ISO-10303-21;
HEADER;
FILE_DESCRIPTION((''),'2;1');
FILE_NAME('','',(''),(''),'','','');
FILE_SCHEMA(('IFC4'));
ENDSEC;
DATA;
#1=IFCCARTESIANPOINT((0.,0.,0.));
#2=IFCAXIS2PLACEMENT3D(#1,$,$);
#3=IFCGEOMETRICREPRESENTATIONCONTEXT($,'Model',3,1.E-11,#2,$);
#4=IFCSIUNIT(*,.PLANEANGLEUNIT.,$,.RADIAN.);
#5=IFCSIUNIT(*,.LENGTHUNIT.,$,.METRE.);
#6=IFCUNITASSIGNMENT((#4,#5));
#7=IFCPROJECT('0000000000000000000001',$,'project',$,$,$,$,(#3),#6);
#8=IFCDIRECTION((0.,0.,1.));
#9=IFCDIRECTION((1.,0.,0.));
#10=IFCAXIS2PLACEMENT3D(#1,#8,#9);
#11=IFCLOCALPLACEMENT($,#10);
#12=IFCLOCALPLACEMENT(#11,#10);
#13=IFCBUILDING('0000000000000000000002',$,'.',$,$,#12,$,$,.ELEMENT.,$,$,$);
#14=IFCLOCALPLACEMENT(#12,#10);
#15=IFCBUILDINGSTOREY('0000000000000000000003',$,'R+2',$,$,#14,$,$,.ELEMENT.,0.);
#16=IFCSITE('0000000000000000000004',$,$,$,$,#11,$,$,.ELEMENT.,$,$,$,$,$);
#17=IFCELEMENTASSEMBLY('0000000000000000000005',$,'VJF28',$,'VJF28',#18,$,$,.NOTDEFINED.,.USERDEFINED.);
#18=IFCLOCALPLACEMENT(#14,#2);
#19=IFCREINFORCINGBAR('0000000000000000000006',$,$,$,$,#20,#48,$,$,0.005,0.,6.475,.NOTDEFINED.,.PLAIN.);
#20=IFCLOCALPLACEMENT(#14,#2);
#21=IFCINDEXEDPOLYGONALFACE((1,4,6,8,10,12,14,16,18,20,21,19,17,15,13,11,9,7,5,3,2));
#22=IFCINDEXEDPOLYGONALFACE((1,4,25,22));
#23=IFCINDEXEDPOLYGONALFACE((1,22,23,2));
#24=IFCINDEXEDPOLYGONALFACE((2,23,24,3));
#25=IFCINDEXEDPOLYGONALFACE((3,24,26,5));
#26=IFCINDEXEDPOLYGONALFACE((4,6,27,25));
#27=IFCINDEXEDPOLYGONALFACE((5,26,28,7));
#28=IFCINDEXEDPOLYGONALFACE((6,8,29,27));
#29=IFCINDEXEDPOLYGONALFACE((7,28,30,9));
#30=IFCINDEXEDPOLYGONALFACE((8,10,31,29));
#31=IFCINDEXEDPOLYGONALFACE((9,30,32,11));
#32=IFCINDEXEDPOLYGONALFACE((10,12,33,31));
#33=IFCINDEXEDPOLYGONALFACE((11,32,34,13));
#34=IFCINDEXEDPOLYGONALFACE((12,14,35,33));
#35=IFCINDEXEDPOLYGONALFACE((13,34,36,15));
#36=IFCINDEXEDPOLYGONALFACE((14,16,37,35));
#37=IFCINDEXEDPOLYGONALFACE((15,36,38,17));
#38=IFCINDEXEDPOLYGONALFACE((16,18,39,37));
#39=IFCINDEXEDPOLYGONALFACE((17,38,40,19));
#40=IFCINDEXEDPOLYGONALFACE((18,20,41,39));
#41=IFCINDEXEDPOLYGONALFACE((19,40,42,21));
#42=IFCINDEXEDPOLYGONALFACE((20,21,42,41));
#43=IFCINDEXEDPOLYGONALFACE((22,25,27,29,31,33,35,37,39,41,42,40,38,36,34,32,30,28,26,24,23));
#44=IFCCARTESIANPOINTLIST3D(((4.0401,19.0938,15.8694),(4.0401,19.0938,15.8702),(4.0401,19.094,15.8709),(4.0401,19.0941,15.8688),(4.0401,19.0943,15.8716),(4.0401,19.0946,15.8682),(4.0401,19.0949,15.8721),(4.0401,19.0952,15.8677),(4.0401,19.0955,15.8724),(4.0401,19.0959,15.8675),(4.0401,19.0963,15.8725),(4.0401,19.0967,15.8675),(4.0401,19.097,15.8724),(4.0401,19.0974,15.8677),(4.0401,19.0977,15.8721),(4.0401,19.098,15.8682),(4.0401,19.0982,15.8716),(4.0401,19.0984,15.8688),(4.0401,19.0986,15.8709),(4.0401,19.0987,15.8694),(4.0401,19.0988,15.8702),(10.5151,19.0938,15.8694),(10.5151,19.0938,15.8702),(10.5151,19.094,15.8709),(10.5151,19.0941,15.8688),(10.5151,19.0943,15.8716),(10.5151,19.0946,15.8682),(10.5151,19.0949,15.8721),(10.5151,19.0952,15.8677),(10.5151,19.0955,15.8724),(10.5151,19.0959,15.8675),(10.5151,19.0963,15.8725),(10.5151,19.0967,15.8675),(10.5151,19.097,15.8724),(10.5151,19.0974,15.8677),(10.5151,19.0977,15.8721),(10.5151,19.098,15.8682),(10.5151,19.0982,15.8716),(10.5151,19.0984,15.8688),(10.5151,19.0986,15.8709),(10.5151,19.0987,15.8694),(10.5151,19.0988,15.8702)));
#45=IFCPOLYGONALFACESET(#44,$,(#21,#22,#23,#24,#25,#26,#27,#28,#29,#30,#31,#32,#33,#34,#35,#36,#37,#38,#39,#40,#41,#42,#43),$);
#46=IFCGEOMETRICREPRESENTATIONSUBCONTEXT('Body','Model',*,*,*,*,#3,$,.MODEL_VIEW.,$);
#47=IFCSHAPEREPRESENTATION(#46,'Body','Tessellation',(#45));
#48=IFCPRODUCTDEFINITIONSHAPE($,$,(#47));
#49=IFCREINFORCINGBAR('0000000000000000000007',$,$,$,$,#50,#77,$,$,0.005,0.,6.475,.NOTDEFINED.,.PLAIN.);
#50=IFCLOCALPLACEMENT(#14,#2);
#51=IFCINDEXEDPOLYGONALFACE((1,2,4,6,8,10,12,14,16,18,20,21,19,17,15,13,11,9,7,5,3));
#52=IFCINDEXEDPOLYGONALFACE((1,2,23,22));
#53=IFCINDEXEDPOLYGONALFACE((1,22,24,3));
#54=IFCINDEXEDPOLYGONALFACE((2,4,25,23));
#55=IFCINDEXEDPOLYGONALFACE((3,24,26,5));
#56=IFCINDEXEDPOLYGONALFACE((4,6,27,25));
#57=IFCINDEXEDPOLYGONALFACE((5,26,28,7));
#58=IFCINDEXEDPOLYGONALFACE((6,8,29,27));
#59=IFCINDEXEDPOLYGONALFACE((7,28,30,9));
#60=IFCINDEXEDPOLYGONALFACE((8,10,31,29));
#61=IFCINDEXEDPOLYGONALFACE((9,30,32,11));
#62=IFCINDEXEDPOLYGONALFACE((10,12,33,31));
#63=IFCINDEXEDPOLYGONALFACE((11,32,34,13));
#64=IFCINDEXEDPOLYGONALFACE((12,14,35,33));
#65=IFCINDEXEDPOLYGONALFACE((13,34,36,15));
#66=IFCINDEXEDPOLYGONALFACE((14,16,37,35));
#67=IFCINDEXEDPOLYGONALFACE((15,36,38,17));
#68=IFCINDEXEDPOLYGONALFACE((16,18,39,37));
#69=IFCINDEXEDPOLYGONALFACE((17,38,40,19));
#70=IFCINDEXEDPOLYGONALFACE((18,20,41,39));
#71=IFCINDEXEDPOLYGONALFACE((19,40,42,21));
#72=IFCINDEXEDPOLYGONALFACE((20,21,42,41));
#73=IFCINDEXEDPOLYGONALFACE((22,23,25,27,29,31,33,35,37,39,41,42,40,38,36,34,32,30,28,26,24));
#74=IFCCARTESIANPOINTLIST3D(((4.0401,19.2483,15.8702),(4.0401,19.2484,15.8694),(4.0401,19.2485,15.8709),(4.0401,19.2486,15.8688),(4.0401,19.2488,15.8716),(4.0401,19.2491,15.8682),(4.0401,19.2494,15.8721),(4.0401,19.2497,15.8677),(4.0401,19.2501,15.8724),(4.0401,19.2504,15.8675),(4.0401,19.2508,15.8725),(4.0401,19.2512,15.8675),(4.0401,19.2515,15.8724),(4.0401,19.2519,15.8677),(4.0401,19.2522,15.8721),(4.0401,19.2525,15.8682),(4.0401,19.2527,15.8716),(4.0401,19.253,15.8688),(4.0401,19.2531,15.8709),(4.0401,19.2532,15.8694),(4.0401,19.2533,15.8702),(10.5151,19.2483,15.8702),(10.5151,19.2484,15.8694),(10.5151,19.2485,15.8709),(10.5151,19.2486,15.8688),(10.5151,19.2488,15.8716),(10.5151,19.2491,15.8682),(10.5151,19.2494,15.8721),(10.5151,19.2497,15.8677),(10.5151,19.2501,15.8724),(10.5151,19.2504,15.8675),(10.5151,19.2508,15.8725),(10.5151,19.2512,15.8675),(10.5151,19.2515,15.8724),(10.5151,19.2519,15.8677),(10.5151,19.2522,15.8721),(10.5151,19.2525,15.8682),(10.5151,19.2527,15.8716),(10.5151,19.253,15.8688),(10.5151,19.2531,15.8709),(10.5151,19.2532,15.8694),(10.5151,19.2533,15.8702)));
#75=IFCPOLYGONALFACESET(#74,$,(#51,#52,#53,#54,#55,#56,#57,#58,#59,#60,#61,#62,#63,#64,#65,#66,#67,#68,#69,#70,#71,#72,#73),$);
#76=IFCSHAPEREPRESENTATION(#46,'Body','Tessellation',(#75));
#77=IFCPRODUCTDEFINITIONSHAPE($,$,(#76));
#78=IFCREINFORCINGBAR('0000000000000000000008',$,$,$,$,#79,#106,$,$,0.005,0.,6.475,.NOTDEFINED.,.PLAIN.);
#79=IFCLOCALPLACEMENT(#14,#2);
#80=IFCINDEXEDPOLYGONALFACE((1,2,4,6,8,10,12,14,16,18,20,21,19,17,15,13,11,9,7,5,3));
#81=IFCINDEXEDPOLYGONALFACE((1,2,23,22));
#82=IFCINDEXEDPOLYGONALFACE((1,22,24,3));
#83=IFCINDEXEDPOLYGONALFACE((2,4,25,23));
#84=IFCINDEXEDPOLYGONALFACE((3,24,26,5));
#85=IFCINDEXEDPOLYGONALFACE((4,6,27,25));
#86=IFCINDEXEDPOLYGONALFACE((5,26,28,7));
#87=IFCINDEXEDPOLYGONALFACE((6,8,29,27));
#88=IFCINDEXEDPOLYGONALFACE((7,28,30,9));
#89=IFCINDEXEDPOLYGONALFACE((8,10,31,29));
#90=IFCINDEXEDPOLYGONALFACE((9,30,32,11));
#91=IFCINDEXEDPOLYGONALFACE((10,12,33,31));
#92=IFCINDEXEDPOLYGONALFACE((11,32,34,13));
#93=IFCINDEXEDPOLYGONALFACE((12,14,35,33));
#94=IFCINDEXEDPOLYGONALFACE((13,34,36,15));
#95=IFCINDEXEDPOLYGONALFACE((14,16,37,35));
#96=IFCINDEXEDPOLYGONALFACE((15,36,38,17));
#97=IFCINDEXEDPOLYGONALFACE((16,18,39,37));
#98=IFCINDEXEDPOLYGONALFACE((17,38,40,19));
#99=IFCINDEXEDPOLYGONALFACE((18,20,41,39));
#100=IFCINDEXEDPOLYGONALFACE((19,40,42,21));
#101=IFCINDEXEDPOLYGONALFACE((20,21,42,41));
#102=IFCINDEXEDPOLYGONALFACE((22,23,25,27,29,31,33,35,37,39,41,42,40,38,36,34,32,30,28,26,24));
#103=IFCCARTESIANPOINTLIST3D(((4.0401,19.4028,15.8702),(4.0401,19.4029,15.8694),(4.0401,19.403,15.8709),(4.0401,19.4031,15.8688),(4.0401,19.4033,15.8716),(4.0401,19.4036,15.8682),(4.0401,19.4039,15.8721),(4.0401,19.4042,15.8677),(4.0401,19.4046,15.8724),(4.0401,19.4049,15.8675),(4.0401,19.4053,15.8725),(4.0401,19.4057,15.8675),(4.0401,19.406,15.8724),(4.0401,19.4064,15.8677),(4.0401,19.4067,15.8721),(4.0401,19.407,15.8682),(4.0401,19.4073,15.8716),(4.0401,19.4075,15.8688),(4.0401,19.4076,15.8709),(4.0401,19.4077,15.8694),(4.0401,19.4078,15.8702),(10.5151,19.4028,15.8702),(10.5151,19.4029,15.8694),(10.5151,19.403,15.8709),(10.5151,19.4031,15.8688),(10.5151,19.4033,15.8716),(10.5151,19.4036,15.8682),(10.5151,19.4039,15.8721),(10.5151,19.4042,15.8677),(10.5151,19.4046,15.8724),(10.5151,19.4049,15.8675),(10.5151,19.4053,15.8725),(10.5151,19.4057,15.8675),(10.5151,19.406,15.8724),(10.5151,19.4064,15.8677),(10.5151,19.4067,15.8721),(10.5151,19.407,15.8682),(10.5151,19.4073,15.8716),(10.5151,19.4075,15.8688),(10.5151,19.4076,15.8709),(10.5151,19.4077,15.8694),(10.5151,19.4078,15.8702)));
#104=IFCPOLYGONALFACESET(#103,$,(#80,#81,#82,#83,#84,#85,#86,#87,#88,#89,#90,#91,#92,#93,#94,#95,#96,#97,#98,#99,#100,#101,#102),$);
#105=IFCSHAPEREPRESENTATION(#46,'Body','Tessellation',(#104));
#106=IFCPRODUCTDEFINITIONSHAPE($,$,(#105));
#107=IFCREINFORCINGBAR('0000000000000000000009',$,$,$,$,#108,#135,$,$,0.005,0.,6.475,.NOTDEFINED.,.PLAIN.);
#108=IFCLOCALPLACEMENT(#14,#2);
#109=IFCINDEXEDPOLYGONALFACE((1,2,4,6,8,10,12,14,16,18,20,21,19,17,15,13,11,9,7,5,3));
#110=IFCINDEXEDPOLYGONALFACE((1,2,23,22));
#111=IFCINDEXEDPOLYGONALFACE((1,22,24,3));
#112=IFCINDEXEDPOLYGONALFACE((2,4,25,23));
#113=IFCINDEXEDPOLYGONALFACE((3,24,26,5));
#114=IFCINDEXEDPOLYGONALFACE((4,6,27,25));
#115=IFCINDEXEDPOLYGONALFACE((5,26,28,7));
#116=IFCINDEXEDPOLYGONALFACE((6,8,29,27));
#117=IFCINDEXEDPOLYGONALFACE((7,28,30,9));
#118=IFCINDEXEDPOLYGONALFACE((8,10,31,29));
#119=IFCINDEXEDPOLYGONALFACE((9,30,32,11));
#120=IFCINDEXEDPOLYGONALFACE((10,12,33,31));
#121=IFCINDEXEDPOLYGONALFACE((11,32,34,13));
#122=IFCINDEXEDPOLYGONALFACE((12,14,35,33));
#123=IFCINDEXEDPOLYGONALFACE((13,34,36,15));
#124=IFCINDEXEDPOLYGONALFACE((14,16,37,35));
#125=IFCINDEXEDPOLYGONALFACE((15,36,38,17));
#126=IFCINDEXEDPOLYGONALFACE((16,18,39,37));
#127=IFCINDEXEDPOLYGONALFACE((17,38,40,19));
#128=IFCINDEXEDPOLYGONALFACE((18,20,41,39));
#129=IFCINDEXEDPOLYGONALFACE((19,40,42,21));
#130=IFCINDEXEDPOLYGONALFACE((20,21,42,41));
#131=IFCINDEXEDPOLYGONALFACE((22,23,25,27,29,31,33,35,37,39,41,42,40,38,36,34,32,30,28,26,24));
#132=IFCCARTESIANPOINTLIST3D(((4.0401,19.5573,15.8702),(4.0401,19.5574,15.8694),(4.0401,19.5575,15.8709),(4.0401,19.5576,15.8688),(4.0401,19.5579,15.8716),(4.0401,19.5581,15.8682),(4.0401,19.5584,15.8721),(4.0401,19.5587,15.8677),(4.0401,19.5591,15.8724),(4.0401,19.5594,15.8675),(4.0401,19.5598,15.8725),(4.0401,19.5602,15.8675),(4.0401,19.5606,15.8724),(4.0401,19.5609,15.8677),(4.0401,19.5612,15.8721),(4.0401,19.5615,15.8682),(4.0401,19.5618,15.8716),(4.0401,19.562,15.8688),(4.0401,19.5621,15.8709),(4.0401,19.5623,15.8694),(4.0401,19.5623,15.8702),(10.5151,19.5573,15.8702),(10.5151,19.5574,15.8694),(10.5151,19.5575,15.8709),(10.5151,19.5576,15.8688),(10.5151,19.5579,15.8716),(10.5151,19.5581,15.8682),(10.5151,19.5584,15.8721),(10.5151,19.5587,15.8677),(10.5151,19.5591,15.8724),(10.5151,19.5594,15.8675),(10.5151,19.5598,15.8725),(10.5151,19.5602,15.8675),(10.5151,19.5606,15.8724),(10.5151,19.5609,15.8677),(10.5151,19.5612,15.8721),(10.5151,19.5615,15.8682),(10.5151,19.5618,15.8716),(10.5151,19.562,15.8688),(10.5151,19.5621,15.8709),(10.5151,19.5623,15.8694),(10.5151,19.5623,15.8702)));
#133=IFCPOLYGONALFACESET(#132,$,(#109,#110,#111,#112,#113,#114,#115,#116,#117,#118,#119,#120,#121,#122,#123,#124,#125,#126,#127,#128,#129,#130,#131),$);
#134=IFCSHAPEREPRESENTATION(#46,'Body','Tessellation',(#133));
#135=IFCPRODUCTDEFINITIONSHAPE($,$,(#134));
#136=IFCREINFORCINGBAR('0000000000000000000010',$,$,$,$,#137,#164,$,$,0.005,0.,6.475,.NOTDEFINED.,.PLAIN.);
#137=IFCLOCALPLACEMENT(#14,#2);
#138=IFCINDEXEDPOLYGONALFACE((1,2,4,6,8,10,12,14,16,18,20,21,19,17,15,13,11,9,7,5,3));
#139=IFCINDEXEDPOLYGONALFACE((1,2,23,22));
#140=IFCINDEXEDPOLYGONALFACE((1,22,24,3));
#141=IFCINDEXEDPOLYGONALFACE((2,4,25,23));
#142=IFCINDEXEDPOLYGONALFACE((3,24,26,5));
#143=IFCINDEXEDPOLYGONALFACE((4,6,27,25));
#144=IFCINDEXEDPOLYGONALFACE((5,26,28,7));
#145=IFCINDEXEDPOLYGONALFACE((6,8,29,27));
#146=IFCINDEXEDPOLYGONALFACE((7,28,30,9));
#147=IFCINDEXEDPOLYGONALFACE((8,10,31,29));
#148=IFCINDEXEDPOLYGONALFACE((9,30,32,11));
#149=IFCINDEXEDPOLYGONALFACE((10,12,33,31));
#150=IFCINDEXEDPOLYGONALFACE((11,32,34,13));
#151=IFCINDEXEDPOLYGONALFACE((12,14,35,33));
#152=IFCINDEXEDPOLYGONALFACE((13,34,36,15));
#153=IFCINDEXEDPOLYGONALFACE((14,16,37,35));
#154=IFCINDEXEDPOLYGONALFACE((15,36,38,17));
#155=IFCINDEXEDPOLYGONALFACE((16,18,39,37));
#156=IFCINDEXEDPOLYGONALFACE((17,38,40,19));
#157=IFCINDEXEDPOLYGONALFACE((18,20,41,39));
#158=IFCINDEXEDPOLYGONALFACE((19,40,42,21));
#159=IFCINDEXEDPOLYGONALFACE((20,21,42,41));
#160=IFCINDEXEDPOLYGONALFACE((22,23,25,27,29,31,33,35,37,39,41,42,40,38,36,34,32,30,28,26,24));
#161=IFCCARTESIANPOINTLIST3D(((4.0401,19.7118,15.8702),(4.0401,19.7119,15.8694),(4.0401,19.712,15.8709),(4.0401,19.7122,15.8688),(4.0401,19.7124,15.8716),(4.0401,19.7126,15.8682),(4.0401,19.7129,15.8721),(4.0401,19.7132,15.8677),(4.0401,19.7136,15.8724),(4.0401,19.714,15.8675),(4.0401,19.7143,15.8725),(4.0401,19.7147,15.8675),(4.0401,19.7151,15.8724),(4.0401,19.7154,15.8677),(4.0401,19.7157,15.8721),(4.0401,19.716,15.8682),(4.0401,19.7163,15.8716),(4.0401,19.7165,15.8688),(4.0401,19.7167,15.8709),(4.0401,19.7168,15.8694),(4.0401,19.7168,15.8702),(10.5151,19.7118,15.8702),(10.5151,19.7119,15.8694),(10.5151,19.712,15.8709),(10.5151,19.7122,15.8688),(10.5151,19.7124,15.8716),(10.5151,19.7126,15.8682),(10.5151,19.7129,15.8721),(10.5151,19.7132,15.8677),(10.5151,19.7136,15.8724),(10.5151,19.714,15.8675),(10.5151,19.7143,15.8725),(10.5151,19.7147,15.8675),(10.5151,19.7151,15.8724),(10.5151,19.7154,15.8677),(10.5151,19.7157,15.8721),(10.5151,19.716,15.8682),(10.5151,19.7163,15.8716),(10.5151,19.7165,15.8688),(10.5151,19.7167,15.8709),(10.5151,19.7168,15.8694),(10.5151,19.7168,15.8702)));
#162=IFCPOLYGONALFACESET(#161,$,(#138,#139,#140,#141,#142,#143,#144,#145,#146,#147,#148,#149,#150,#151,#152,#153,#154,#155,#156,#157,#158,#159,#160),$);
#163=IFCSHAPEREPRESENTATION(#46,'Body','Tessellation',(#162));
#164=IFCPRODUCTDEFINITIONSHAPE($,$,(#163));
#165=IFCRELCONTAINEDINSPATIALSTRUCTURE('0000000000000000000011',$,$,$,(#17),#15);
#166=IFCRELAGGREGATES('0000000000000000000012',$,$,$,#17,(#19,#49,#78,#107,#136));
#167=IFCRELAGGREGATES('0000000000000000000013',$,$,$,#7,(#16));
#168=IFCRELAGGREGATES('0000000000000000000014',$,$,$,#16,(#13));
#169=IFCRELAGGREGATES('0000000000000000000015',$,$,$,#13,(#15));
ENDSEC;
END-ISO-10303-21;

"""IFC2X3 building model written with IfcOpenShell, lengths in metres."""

from ifc_helpers import new_model, entity, si_unit, origin, origin_with_axes, place, context, subcontext, project, spatial, shape, element, aggregate, save


model = new_model("IFC2X3")

# Units and contexts
model_context = context("Model", 3, precision=1e-11, world=origin())
body_context = subcontext(model_context, "Body", "Model", "MODEL_VIEW")
ifc_project = project(units=[si_unit("PLANEANGLEUNIT", "RADIAN"), si_unit("LENGTHUNIT", "METRE")], contexts=[model_context])

# Site, building, storey
site_placement = place(None, origin_with_axes())
site = spatial("IfcSite", under=ifc_project, at=site_placement, CompositionType="ELEMENT")
building_placement = place(site_placement, origin_with_axes())
building = spatial("IfcBuilding", under=site, at=building_placement, Name=".", CompositionType="ELEMENT")
storey_placement = place(building_placement, origin_with_axes())
storey = spatial("IfcBuildingStorey", under=building, at=storey_placement, Name="R+2", CompositionType="ELEMENT", Elevation=0.0)

# Element assembly, reinforcing bars
assembly_1_placement = place(storey_placement, origin_with_axes())
assembly_1 = element("IfcElementAssembly", 1, at=assembly_1_placement, inside=storey, Name="VJF28", ObjectType="VJF28", AssemblyPlace="NOTDEFINED", PredefinedType="USERDEFINED")
reinforcing_bar_1_placement = place(assembly_1_placement, origin_with_axes())
reinforcing_bar_1 = element("IfcReinforcingBar", 2, at=reinforcing_bar_1_placement, BarLength=6.475, BarRole="NOTDEFINED", BarSurface="PLAIN", CrossSectionArea=0.0, NominalDiameter=0.005, shapes=[
    shape(body_context, "Body", "AdvancedSweptSolid", [entity("IfcSweptDiskSolid", entity("IfcPolyline", [entity("IfcCartesianPoint", [4.0401, 19.0963, 15.87]), entity("IfcCartesianPoint", [10.5151, 19.0963, 15.87])]), 0.0025, None, 0.0, 6.475)]),
    shape(body_context, "Body", "AdvancedSweptSolid", [entity("IfcSweptDiskSolid", entity("IfcPolyline", [entity("IfcCartesianPoint", [4.0401, 19.0963, 15.87]), entity("IfcCartesianPoint", [10.5151, 19.0963, 15.87])]), 0.0025, None, 0.0, 6.475)]),
])
reinforcing_bar_2_placement = place(assembly_1_placement, origin_with_axes())
reinforcing_bar_2 = element("IfcReinforcingBar", 3, at=reinforcing_bar_2_placement, BarLength=6.475, BarRole="NOTDEFINED", BarSurface="PLAIN", CrossSectionArea=0.0, NominalDiameter=0.005, shapes=[
    shape(body_context, "Body", "AdvancedSweptSolid", [entity("IfcSweptDiskSolid", entity("IfcPolyline", [entity("IfcCartesianPoint", [4.0401, 19.2508, 15.87]), entity("IfcCartesianPoint", [10.5151, 19.2508, 15.87])]), 0.0025, None, 0.0, 6.475)]),
    shape(body_context, "Body", "AdvancedSweptSolid", [entity("IfcSweptDiskSolid", entity("IfcPolyline", [entity("IfcCartesianPoint", [4.0401, 19.2508, 15.87]), entity("IfcCartesianPoint", [10.5151, 19.2508, 15.87])]), 0.0025, None, 0.0, 6.475)]),
])
reinforcing_bar_3_placement = place(assembly_1_placement, origin_with_axes())
reinforcing_bar_3 = element("IfcReinforcingBar", 4, at=reinforcing_bar_3_placement, BarLength=6.475, BarRole="NOTDEFINED", BarSurface="PLAIN", CrossSectionArea=0.0, NominalDiameter=0.005, shapes=[
    shape(body_context, "Body", "AdvancedSweptSolid", [entity("IfcSweptDiskSolid", entity("IfcPolyline", [entity("IfcCartesianPoint", [4.0401, 19.4053, 15.87]), entity("IfcCartesianPoint", [10.5151, 19.4053, 15.87])]), 0.0025, None, 0.0, 6.475)]),
    shape(body_context, "Body", "AdvancedSweptSolid", [entity("IfcSweptDiskSolid", entity("IfcPolyline", [entity("IfcCartesianPoint", [4.0401, 19.4053, 15.87]), entity("IfcCartesianPoint", [10.5151, 19.4053, 15.87])]), 0.0025, None, 0.0, 6.475)]),
])
reinforcing_bar_4_placement = place(assembly_1_placement, origin_with_axes())
reinforcing_bar_4 = element("IfcReinforcingBar", 5, at=reinforcing_bar_4_placement, BarLength=6.475, BarRole="NOTDEFINED", BarSurface="PLAIN", CrossSectionArea=0.0, NominalDiameter=0.005, shapes=[
    shape(body_context, "Body", "AdvancedSweptSolid", [entity("IfcSweptDiskSolid", entity("IfcPolyline", [entity("IfcCartesianPoint", [4.0401, 19.5598, 15.87]), entity("IfcCartesianPoint", [10.5151, 19.5598, 15.87])]), 0.0025, None, 0.0, 6.475)]),
    shape(body_context, "Body", "AdvancedSweptSolid", [entity("IfcSweptDiskSolid", entity("IfcPolyline", [entity("IfcCartesianPoint", [4.0401, 19.5598, 15.87]), entity("IfcCartesianPoint", [10.5151, 19.5598, 15.87])]), 0.0025, None, 0.0, 6.475)]),
])
reinforcing_bar_5_placement = place(assembly_1_placement, origin_with_axes())
reinforcing_bar_5 = element("IfcReinforcingBar", 6, at=reinforcing_bar_5_placement, BarLength=6.475, BarRole="NOTDEFINED", BarSurface="PLAIN", CrossSectionArea=0.0, NominalDiameter=0.005, shapes=[
    shape(body_context, "Body", "AdvancedSweptSolid", [entity("IfcSweptDiskSolid", entity("IfcPolyline", [entity("IfcCartesianPoint", [4.0401, 19.7143, 15.87]), entity("IfcCartesianPoint", [10.5151, 19.7143, 15.87])]), 0.0025, None, 0.0, 6.475)]),
    shape(body_context, "Body", "AdvancedSweptSolid", [entity("IfcSweptDiskSolid", entity("IfcPolyline", [entity("IfcCartesianPoint", [4.0401, 19.7143, 15.87]), entity("IfcCartesianPoint", [10.5151, 19.7143, 15.87])]), 0.0025, None, 0.0, 6.475)]),
])
aggregate(assembly_1, [reinforcing_bar_1, reinforcing_bar_2, reinforcing_bar_3, reinforcing_bar_4, reinforcing_bar_5])

save(model, "model.ifc")
